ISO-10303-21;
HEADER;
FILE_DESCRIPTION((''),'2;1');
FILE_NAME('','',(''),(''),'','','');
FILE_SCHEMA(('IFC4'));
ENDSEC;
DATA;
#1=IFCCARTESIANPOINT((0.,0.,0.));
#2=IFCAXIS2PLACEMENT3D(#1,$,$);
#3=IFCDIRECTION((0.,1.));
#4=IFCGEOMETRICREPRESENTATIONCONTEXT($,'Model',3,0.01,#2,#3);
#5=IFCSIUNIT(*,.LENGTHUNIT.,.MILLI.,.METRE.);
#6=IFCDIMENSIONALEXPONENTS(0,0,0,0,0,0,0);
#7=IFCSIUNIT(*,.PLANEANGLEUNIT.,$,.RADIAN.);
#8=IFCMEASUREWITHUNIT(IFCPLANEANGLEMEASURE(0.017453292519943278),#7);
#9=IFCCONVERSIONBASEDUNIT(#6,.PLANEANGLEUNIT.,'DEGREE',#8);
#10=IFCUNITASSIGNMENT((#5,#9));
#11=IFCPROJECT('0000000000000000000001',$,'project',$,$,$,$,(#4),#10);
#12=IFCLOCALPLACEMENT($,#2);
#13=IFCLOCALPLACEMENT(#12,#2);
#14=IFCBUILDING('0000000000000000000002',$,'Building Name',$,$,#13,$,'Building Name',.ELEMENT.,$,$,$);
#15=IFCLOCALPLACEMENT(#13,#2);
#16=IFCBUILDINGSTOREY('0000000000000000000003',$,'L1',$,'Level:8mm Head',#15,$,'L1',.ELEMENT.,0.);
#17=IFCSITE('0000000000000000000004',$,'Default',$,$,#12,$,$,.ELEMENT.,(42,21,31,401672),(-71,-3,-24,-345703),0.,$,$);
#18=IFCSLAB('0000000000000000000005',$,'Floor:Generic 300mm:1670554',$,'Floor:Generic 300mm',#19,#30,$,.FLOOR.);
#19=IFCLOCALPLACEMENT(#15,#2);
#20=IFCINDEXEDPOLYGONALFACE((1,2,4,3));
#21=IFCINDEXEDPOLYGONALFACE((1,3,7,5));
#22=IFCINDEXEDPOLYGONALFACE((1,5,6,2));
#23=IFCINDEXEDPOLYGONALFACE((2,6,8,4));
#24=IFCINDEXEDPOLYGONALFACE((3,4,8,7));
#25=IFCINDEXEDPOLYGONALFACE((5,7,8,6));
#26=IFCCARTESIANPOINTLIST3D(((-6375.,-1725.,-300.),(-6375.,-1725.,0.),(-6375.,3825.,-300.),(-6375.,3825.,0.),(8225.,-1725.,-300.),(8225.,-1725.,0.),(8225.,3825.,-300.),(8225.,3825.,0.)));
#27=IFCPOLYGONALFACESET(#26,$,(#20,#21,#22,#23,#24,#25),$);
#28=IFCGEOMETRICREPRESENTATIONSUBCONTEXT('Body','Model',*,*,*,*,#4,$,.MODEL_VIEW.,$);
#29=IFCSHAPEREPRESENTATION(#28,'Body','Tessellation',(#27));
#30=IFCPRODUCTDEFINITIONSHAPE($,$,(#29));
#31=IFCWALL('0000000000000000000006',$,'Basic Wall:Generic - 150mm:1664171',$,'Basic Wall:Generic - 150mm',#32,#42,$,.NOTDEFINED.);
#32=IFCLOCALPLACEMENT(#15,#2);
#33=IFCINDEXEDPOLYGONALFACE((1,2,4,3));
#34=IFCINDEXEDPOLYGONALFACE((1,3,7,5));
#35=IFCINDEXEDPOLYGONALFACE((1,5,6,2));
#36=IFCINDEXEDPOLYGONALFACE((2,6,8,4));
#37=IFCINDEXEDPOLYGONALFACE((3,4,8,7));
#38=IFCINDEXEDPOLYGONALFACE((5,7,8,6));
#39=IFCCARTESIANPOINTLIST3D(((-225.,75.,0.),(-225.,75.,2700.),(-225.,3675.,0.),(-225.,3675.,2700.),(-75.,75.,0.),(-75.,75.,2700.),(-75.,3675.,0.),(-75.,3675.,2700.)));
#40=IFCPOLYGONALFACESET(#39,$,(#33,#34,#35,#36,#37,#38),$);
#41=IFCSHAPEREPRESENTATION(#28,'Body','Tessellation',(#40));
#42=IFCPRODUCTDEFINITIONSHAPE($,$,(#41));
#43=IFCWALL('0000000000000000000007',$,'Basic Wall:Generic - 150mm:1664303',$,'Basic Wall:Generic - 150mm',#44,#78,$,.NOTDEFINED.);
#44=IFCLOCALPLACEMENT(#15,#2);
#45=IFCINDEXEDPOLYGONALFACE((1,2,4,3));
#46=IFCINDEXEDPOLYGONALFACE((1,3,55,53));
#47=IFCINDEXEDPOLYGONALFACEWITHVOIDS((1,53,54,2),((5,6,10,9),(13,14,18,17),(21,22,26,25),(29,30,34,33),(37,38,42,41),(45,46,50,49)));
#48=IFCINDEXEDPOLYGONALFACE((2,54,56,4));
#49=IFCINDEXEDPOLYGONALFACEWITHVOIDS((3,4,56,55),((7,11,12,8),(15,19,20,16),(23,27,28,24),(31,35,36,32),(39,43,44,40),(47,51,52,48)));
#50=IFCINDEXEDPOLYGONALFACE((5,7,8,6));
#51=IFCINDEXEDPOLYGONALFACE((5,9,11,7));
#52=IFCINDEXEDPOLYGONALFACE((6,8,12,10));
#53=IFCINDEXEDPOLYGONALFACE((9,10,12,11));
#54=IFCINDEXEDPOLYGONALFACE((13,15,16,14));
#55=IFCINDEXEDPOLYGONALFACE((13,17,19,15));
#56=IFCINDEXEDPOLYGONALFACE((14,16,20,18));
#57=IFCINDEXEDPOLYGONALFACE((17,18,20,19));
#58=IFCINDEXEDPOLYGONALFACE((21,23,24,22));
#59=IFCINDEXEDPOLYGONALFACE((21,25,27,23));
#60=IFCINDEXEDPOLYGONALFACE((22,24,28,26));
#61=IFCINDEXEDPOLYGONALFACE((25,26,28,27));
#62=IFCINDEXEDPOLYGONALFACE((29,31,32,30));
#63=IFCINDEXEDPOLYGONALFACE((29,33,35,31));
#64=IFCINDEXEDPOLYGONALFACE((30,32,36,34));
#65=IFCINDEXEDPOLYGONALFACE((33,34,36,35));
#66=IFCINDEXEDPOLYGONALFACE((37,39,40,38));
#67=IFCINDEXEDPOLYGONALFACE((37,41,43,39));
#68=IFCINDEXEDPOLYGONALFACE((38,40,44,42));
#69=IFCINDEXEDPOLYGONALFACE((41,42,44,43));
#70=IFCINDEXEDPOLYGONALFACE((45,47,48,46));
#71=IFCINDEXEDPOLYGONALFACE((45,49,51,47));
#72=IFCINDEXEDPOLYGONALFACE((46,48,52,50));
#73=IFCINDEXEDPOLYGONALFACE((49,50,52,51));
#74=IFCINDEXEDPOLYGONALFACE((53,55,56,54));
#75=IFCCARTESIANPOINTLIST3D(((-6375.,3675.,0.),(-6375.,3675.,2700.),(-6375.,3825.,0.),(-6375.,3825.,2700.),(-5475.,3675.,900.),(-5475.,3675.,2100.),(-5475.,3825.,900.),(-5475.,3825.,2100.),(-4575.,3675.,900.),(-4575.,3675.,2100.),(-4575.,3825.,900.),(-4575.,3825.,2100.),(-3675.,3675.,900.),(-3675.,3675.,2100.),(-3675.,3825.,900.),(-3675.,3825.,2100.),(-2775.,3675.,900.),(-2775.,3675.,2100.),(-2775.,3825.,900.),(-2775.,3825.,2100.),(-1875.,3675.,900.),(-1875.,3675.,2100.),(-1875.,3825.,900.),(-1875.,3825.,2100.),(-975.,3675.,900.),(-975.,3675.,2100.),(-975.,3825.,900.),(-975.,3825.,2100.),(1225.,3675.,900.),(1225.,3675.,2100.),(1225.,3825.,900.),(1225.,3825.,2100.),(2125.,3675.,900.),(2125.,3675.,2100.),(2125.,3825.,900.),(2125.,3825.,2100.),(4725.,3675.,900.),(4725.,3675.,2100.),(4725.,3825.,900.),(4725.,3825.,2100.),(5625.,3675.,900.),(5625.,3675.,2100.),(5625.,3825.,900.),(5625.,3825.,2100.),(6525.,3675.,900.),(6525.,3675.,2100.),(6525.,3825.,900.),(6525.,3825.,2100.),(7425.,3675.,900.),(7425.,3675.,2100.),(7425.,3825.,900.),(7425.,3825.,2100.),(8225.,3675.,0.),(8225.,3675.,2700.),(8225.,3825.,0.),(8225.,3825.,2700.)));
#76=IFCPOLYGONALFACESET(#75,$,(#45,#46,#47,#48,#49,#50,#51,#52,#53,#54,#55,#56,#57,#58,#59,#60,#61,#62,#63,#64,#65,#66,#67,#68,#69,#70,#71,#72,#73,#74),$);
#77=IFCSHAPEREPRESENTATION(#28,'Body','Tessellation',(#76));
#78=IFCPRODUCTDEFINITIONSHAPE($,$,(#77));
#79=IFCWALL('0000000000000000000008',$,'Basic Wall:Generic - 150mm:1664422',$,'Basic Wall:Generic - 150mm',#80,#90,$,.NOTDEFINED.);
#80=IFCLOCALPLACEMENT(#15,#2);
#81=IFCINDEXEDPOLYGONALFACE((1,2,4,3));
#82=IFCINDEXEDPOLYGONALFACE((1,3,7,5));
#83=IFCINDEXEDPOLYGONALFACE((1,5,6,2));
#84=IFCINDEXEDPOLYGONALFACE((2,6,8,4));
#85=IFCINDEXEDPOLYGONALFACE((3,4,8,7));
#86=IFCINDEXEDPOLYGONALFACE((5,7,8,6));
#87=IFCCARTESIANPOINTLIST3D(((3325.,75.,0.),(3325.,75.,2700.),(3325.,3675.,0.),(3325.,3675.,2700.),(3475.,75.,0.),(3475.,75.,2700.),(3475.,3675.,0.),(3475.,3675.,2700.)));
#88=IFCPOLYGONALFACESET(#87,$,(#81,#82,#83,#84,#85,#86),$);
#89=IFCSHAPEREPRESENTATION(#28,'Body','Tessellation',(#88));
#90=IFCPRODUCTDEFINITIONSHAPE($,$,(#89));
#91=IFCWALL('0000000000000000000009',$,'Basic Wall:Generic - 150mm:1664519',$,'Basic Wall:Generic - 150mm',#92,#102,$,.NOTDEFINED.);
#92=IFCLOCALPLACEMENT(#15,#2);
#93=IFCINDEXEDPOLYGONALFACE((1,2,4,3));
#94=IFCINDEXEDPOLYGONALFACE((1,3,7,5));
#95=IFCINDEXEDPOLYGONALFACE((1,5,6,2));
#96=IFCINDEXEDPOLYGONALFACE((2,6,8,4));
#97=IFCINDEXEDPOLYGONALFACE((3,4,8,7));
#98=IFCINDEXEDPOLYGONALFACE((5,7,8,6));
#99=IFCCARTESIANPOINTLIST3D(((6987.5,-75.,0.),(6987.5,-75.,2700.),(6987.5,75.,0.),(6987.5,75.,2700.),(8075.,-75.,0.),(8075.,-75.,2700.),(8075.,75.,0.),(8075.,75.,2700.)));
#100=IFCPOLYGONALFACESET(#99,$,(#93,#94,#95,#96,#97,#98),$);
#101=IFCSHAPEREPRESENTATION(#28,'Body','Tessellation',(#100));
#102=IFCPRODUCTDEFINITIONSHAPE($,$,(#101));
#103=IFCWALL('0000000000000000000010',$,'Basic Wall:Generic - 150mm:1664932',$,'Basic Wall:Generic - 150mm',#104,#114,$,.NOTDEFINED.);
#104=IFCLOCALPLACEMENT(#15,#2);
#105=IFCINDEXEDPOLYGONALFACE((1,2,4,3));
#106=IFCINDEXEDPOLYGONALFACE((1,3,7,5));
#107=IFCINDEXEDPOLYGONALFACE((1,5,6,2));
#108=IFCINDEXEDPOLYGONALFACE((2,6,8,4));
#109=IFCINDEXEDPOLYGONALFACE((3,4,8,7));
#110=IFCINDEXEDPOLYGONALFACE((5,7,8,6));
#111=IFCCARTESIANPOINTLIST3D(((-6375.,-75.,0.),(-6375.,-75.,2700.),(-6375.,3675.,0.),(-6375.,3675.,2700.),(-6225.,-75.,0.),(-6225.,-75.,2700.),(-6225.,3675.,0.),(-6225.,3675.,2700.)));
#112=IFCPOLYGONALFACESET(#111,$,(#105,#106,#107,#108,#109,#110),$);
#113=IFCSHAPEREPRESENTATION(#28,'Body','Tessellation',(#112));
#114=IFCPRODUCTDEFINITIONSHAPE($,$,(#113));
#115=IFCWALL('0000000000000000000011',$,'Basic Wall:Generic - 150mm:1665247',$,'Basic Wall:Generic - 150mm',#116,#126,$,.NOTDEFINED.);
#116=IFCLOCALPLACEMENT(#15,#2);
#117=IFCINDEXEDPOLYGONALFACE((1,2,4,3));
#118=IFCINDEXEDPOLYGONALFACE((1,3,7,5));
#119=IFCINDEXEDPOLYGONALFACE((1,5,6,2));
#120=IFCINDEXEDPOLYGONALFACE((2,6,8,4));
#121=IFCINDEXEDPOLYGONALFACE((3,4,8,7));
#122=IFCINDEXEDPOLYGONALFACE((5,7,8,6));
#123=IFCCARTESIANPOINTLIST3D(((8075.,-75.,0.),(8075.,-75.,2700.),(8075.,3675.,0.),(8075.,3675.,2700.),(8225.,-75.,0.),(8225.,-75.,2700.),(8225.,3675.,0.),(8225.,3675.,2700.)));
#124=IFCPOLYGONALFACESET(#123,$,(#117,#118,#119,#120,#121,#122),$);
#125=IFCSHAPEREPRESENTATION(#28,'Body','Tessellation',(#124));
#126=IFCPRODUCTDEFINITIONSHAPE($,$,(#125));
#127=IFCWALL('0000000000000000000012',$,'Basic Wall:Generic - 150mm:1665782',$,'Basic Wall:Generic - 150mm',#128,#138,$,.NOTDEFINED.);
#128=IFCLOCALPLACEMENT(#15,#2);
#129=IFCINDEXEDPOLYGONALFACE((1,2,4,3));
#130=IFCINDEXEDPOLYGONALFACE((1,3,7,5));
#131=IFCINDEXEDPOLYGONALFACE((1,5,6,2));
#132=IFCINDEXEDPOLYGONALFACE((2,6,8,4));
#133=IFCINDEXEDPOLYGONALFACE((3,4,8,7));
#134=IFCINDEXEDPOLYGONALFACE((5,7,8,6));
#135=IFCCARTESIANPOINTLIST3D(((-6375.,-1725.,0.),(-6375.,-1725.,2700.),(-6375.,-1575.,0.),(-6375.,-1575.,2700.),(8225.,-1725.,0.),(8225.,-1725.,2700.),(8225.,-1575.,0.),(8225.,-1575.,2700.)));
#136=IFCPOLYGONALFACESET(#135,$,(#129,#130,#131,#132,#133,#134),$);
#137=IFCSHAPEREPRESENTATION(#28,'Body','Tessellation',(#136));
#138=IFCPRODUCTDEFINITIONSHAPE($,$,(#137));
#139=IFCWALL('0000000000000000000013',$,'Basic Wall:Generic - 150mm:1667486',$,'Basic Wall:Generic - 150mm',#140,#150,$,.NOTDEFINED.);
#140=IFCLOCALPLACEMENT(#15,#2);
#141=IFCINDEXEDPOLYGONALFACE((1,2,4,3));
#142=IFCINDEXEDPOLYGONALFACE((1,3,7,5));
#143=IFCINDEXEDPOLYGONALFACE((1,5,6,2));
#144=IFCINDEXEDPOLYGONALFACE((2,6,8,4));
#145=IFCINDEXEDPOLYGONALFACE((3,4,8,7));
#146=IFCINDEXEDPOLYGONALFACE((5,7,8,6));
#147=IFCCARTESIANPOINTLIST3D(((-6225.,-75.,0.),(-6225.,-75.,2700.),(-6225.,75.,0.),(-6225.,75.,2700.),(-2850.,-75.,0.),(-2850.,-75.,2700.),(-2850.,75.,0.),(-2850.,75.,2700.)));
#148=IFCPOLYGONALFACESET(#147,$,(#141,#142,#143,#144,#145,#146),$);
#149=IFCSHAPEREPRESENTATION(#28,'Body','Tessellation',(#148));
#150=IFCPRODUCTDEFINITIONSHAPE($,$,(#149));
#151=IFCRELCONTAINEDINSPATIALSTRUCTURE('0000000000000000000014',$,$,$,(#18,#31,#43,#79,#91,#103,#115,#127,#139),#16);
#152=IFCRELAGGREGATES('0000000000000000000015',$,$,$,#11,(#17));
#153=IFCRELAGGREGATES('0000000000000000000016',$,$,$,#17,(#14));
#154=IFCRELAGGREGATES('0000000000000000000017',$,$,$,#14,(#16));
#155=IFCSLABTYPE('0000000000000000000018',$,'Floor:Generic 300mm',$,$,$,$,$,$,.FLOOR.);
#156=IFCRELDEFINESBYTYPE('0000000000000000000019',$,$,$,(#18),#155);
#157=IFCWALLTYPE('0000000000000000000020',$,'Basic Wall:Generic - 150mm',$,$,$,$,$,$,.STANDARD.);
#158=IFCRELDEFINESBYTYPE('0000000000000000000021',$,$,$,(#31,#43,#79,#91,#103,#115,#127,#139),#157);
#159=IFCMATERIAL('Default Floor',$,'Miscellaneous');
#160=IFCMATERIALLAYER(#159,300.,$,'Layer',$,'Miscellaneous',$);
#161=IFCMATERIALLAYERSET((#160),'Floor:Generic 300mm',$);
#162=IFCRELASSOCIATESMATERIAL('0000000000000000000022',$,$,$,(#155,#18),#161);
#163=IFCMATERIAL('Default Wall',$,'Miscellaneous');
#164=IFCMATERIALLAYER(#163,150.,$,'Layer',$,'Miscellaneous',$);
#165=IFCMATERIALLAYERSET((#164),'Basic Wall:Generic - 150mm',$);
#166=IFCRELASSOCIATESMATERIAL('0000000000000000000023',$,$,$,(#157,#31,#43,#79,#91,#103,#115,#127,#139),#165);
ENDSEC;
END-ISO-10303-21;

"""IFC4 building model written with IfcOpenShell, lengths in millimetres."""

from ifc_helpers import new_model, entity, si_unit, converted_unit, direction, frame, frame_2d, origin, place, context, subcontext, project, spatial, rectangle, extrude, material, layer, layer_set, layer_usage, type_object, element, save


model = new_model("IFC4")

# Units and contexts
model_context = context("Model", 3, precision=0.01, world=origin(), true_north=direction((0.0, 1.0)))
body_context = subcontext(model_context, "Body", "Model", "MODEL_VIEW")
ifc_project = project(units=[si_unit("LENGTHUNIT", "METRE", prefix="MILLI"), converted_unit("PLANEANGLEUNIT", "DEGREE", entity("IfcPlaneAngleMeasure", 0.017453292519943278), si_unit("PLANEANGLEUNIT", "RADIAN"), dimensions=[0, 0, 0, 0, 0, 0, 0])], contexts=[model_context])

# Site, building, storey
site_placement = place(None, origin())
site = spatial("IfcSite", under=ifc_project, at=site_placement, Name="Default", CompositionType="ELEMENT", RefLatitude=(42, 21, 31, 401672), RefLongitude=(-71, -3, -24, -345703), RefElevation=0.0)
building_placement = place(site_placement, origin())
building = spatial("IfcBuilding", under=site, at=building_placement, Name="Building Name", LongName="Building Name", CompositionType="ELEMENT")
storey_placement = place(building_placement, origin())
storey = spatial("IfcBuildingStorey", under=building, at=storey_placement, Name="L1", ObjectType="Level:8mm Head", LongName="L1", CompositionType="ELEMENT", Elevation=0.0)

# Slab
ifc_material_1 = material(Name="Default Floor", Category="Miscellaneous")
ifc_layer_1 = layer(ifc_material_1, 300.0, Name="Layer", Category="Miscellaneous")
ifc_layer_set_1 = layer_set([ifc_layer_1], Name="Floor:Generic 300mm")
ifc_layer_usage_1 = layer_usage(ifc_layer_set_1, "AXIS3", "POSITIVE", 0.0)
slab_type = type_object("IfcSlabType", Name="Floor:Generic 300mm", PredefinedType="FLOOR", material=ifc_layer_set_1)
slab_placement = place(storey_placement, origin())
element("IfcSlab", 1, at=slab_placement, inside=storey, type_object=slab_type, material=ifc_layer_usage_1, Name="Floor:Generic 300mm:1670554", ObjectType="Floor:Generic 300mm", PredefinedType="FLOOR", context=body_context, shape_type="SweptSolid", body=[
    extrude(rectangle(XDim=5550.0, YDim=14600.0, at=frame_2d((0.0, 0.0), x_axis=(1.0, 0.0))), frame((925.0, 1050.0, 0.0), z_axis=(0.0, 0.0, -1.0), x_axis=(0.0, 1.0, 0.0)), (0.0, 0.0, 1.0), 300.0),
])

# Wall
ifc_material_2 = material(Name="Default Wall", Category="Miscellaneous")
ifc_layer_2 = layer(ifc_material_2, 150.0, Name="Layer", Category="Miscellaneous")
ifc_layer_set_2 = layer_set([ifc_layer_2], Name="Basic Wall:Generic - 150mm")
ifc_layer_usage_2 = layer_usage(ifc_layer_set_2, "AXIS2", "NEGATIVE", 75.0)
wall_type = type_object("IfcWallType", Name="Basic Wall:Generic - 150mm", PredefinedType="STANDARD", material=ifc_layer_set_2)
wall_1_placement = place(storey_placement, frame((-150.0, 75.0, 0.0), z_axis=(0.0, 0.0, 1.0), x_axis=(0.0, 1.0, 0.0)))
element("IfcWall", 2, at=wall_1_placement, inside=storey, type_object=wall_type, material=ifc_layer_usage_2, Name="Basic Wall:Generic - 150mm:1664171", ObjectType="Basic Wall:Generic - 150mm", PredefinedType="NOTDEFINED", context=body_context, shape_type="SweptSolid", body=[
    extrude(rectangle(XDim=3600.0, YDim=150.0, at=frame_2d((1800.0, 0.0), x_axis=(-1.0, 0.0))), origin(), (0.0, 0.0, 1.0), 2700.0),
])

# Wall, openings
ifc_layer_usage_3 = layer_usage(ifc_layer_set_2, "AXIS2", "NEGATIVE", 75.0)
wall_2_placement = place(storey_placement, frame((-6375.0, 3750.0, 0.0)))
wall_2 = element("IfcWall", 3, at=wall_2_placement, inside=storey, type_object=wall_type, material=ifc_layer_usage_3, Name="Basic Wall:Generic - 150mm:1664303", ObjectType="Basic Wall:Generic - 150mm", PredefinedType="NOTDEFINED", context=body_context, shape_type="SweptSolid", body=[
    extrude(rectangle(XDim=14600.0, YDim=150.0, at=frame_2d((7300.0, 0.0), x_axis=(-1.0, 0.0))), origin(), (0.0, 0.0, 1.0), 2700.0),
])
opening_1_placement = place(wall_2_placement, frame((7600.0, -75.0, 900.0)))
element("IfcOpeningElement", 4, at=opening_1_placement, cuts=wall_2, PredefinedType="OPENING", context=body_context, shape_type="SweptSolid", body=[
    extrude(rectangle(XDim=1200.0, YDim=900.0, at=frame_2d((600.0, 450.0), x_axis=(-1.0, 0.0))), frame((0.0, 0.0, 0.0), z_axis=(0.0, 1.0, 0.0), x_axis=(0.0, 0.0, 1.0)), (0.0, 0.0, 1.0), 150.0),
])
opening_2_placement = place(wall_2_placement, frame((4500.0, -75.0, 900.0)))
element("IfcOpeningElement", 5, at=opening_2_placement, cuts=wall_2, PredefinedType="OPENING", context=body_context, shape_type="SweptSolid", body=[
    extrude(rectangle(XDim=1200.0, YDim=900.0, at=frame_2d((600.0, 450.0), x_axis=(-1.0, 0.0))), frame((0.0, 0.0, 0.0), z_axis=(0.0, 1.0, 0.0), x_axis=(0.0, 0.0, 1.0)), (0.0, 0.0, 1.0), 150.0),
])
opening_3_placement = place(wall_2_placement, frame((2700.0, -75.0, 900.0)))
element("IfcOpeningElement", 6, at=opening_3_placement, cuts=wall_2, PredefinedType="OPENING", context=body_context, shape_type="SweptSolid", body=[
    extrude(rectangle(XDim=1200.0, YDim=900.0, at=frame_2d((600.0, 450.0), x_axis=(-1.0, 0.0))), frame((0.0, 0.0, 0.0), z_axis=(0.0, 1.0, 0.0), x_axis=(0.0, 0.0, 1.0)), (0.0, 0.0, 1.0), 150.0),
])
opening_4_placement = place(wall_2_placement, frame((900.0, -75.0, 900.0)))
element("IfcOpeningElement", 7, at=opening_4_placement, cuts=wall_2, PredefinedType="OPENING", context=body_context, shape_type="SweptSolid", body=[
    extrude(rectangle(XDim=1200.0, YDim=900.0, at=frame_2d((600.0, 450.0), x_axis=(-1.0, 0.0))), frame((0.0, 0.0, 0.0), z_axis=(0.0, 1.0, 0.0), x_axis=(0.0, 0.0, 1.0)), (0.0, 0.0, 1.0), 150.0),
])
opening_5_placement = place(wall_2_placement, frame((11100.0, -75.0, 900.0)))
element("IfcOpeningElement", 8, at=opening_5_placement, cuts=wall_2, PredefinedType="OPENING", context=body_context, shape_type="SweptSolid", body=[
    extrude(rectangle(XDim=1200.0, YDim=900.0, at=frame_2d((600.0, 450.0), x_axis=(-1.0, 0.0))), frame((0.0, 0.0, 0.0), z_axis=(0.0, 1.0, 0.0), x_axis=(0.0, 0.0, 1.0)), (0.0, 0.0, 1.0), 150.0),
])
opening_6_placement = place(wall_2_placement, frame((12900.0, -75.0, 900.0)))
element("IfcOpeningElement", 9, at=opening_6_placement, cuts=wall_2, PredefinedType="OPENING", context=body_context, shape_type="SweptSolid", body=[
    extrude(rectangle(XDim=1200.0, YDim=900.0, at=frame_2d((600.0, 450.0), x_axis=(-1.0, 0.0))), frame((0.0, 0.0, 0.0), z_axis=(0.0, 1.0, 0.0), x_axis=(0.0, 0.0, 1.0)), (0.0, 0.0, 1.0), 150.0),
])

# Walls
ifc_layer_usage_4 = layer_usage(ifc_layer_set_2, "AXIS2", "NEGATIVE", 75.0)
wall_3_placement = place(storey_placement, frame((3400.0, 3675.0, 0.0), z_axis=(0.0, 0.0, 1.0), x_axis=(0.0, -1.0, 0.0)))
element("IfcWall", 10, at=wall_3_placement, inside=storey, type_object=wall_type, material=ifc_layer_usage_4, Name="Basic Wall:Generic - 150mm:1664422", ObjectType="Basic Wall:Generic - 150mm", PredefinedType="NOTDEFINED", context=body_context, shape_type="SweptSolid", body=[
    extrude(rectangle(XDim=3600.0, YDim=150.0, at=frame_2d((1800.0, 0.0), x_axis=(-1.0, 0.0))), origin(), (0.0, 0.0, 1.0), 2700.0),
])
ifc_layer_usage_5 = layer_usage(ifc_layer_set_2, "AXIS2", "NEGATIVE", 75.0)
wall_4_placement = place(storey_placement, frame((8075.0, 0.0, 0.0), z_axis=(0.0, 0.0, 1.0), x_axis=(-1.0, 0.0, 0.0)))
element("IfcWall", 11, at=wall_4_placement, inside=storey, type_object=wall_type, material=ifc_layer_usage_5, Name="Basic Wall:Generic - 150mm:1664519", ObjectType="Basic Wall:Generic - 150mm", PredefinedType="NOTDEFINED", context=body_context, shape_type="SweptSolid", body=[
    extrude(rectangle(XDim=1087.5, YDim=150.0, at=frame_2d((543.7, 0.0), x_axis=(-1.0, 0.0))), origin(), (0.0, 0.0, 1.0), 2700.0),
])
ifc_layer_usage_6 = layer_usage(ifc_layer_set_2, "AXIS2", "NEGATIVE", 75.0)
wall_5_placement = place(storey_placement, frame((-6300.0, 3675.0, 0.0), z_axis=(0.0, 0.0, 1.0), x_axis=(0.0, -1.0, 0.0)))
element("IfcWall", 12, at=wall_5_placement, inside=storey, type_object=wall_type, material=ifc_layer_usage_6, Name="Basic Wall:Generic - 150mm:1664932", ObjectType="Basic Wall:Generic - 150mm", PredefinedType="NOTDEFINED", context=body_context, shape_type="SweptSolid", body=[
    extrude(rectangle(XDim=3750.0, YDim=150.0, at=frame_2d((1875.0, 0.0), x_axis=(-1.0, 0.0))), origin(), (0.0, 0.0, 1.0), 2700.0),
])
ifc_layer_usage_7 = layer_usage(ifc_layer_set_2, "AXIS2", "NEGATIVE", 75.0)
wall_6_placement = place(storey_placement, frame((8150.0, 3675.0, 0.0), z_axis=(0.0, 0.0, 1.0), x_axis=(0.0, -1.0, 0.0)))
element("IfcWall", 13, at=wall_6_placement, inside=storey, type_object=wall_type, material=ifc_layer_usage_7, Name="Basic Wall:Generic - 150mm:1665247", ObjectType="Basic Wall:Generic - 150mm", PredefinedType="NOTDEFINED", context=body_context, shape_type="SweptSolid", body=[
    extrude(rectangle(XDim=3750.0, YDim=150.0, at=frame_2d((1875.0, 0.0), x_axis=(-1.0, 0.0))), origin(), (0.0, 0.0, 1.0), 2700.0),
])
ifc_layer_usage_8 = layer_usage(ifc_layer_set_2, "AXIS2", "NEGATIVE", 75.0)
wall_7_placement = place(storey_placement, frame((8225.0, -1650.0, 0.0), z_axis=(0.0, 0.0, 1.0), x_axis=(-1.0, 0.0, 0.0)))
element("IfcWall", 14, at=wall_7_placement, inside=storey, type_object=wall_type, material=ifc_layer_usage_8, Name="Basic Wall:Generic - 150mm:1665782", ObjectType="Basic Wall:Generic - 150mm", PredefinedType="NOTDEFINED", context=body_context, shape_type="SweptSolid", body=[
    extrude(rectangle(XDim=14600.0, YDim=150.0, at=frame_2d((7300.0, 0.0), x_axis=(-1.0, 0.0))), origin(), (0.0, 0.0, 1.0), 2700.0),
])
ifc_layer_usage_9 = layer_usage(ifc_layer_set_2, "AXIS2", "NEGATIVE", 75.0)
wall_8_placement = place(storey_placement, frame((-2850.0, 0.0, 0.0), z_axis=(0.0, 0.0, 1.0), x_axis=(-1.0, 0.0, 0.0)))
element("IfcWall", 15, at=wall_8_placement, inside=storey, type_object=wall_type, material=ifc_layer_usage_9, Name="Basic Wall:Generic - 150mm:1667486", ObjectType="Basic Wall:Generic - 150mm", PredefinedType="NOTDEFINED", context=body_context, shape_type="SweptSolid", body=[
    extrude(rectangle(XDim=3375.0, YDim=150.0, at=frame_2d((1687.5, 0.0), x_axis=(-1.0, 0.0))), origin(), (0.0, 0.0, 1.0), 2700.0),
])

save(model, "model.ifc")
